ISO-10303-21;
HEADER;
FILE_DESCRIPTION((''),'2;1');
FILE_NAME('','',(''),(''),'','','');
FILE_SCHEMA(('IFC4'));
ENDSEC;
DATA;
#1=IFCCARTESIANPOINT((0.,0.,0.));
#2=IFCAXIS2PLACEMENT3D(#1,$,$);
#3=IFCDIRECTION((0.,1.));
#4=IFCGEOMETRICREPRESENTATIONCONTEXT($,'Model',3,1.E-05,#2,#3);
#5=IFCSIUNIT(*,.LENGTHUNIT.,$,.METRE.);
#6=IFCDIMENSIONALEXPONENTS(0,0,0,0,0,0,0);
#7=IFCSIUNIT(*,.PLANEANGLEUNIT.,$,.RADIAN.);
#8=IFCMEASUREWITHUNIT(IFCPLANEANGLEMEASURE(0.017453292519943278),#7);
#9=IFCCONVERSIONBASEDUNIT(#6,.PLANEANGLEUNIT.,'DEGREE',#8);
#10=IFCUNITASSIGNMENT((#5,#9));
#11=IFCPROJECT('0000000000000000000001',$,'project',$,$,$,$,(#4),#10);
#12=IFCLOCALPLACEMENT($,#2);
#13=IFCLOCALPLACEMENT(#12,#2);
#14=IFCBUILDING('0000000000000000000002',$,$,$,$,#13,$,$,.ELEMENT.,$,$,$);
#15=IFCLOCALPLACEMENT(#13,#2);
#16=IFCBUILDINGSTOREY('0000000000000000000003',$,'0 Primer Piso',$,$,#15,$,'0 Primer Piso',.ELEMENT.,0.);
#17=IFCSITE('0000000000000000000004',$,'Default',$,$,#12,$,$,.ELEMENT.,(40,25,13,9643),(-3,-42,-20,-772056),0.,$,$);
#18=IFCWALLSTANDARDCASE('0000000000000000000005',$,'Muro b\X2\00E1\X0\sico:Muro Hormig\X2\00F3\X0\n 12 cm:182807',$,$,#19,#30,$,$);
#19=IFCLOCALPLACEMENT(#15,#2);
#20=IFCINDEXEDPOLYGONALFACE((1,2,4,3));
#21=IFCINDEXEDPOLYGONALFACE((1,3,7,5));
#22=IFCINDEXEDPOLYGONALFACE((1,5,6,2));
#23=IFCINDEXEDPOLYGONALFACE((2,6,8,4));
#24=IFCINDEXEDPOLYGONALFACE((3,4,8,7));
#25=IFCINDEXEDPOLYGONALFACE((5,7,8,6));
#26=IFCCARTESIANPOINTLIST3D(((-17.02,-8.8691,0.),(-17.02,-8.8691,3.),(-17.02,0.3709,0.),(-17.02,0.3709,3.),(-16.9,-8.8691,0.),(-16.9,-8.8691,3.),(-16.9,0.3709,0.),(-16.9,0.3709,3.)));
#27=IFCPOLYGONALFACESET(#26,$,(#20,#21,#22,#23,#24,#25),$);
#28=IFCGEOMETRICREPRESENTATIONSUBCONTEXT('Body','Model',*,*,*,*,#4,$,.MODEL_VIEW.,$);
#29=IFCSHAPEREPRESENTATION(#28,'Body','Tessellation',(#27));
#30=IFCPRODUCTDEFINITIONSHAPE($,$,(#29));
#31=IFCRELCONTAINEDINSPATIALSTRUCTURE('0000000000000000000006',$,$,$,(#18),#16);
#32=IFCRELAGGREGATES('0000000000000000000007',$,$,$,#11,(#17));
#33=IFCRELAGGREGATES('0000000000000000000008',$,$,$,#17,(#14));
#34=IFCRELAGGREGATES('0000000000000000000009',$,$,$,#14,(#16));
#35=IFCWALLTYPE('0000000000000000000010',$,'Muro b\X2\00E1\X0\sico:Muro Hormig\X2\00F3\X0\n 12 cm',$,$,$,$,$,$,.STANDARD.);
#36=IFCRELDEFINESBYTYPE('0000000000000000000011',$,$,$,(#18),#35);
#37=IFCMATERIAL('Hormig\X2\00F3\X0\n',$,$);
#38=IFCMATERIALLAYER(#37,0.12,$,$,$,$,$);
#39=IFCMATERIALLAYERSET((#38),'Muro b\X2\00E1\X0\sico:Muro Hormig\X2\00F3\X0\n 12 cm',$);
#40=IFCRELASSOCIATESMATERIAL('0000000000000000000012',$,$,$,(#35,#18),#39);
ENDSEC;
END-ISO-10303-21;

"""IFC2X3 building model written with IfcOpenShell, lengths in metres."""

from ifc_helpers import new_model, entity, si_unit, converted_unit, direction, frame, frame_2d, origin, place, context, subcontext, project, spatial, rectangle, extrude, material, layer, layer_set, layer_usage, type_object, element, save


model = new_model("IFC2X3")

# Units and contexts
model_context = context("Model", 3, precision=1e-05, world=origin(), true_north=direction((0.0, 1.0)))
body_context = subcontext(model_context, "Body", "Model", "MODEL_VIEW")
ifc_project = project(units=[si_unit("LENGTHUNIT", "METRE"), converted_unit("PLANEANGLEUNIT", "DEGREE", entity("IfcPlaneAngleMeasure", 0.017453292519943278), si_unit("PLANEANGLEUNIT", "RADIAN"), dimensions=[0, 0, 0, 0, 0, 0, 0])], contexts=[model_context])

# Site, building, storey
site_placement = place(None, origin())
site = spatial("IfcSite", under=ifc_project, at=site_placement, Name="Default", CompositionType="ELEMENT", RefLatitude=(40, 25, 13, 9643), RefLongitude=(-3, -42, -20, -772056), RefElevation=0.0)
building_placement = place(site_placement, origin())
building = spatial("IfcBuilding", under=site, at=building_placement, CompositionType="ELEMENT")
storey_placement = place(building_placement, origin())
storey = spatial("IfcBuildingStorey", under=building, at=storey_placement, Name="0 Primer Piso", LongName="0 Primer Piso", CompositionType="ELEMENT", Elevation=0.0)

# Shared definitions
ifc_material = material(Name="Hormigón")
ifc_layer = layer(ifc_material, 0.12)
ifc_layer_set = layer_set([ifc_layer], Name="Muro básico:Muro Hormigón 12 cm")
wall_type = type_object("IfcWallType", Name="Muro básico:Muro Hormigón 12 cm", PredefinedType="STANDARD", material=ifc_layer_set)

# Wall
ifc_layer_usage_1 = layer_usage(ifc_layer_set, "AXIS2", "NEGATIVE", 0.06)
wall_1_placement = place(storey_placement, frame((-16.96, 0.3709, 0.0), z_axis=(0.0, 0.0, 1.0), x_axis=(0.0, -1.0, 0.0)))
element("IfcWallStandardCase", 1, at=wall_1_placement, inside=storey, type_object=wall_type, material=ifc_layer_usage_1, Name="Muro básico:Muro Hormigón 12 cm:182807", context=body_context, shape_type="SweptSolid", body=[
    extrude(rectangle(XDim=9.24, YDim=0.12, at=frame_2d((4.62, 0.0), x_axis=(-1.0, 0.0))), origin(), (0.0, 0.0, 1.0), 3.0),
])

save(model, "model.ifc")
